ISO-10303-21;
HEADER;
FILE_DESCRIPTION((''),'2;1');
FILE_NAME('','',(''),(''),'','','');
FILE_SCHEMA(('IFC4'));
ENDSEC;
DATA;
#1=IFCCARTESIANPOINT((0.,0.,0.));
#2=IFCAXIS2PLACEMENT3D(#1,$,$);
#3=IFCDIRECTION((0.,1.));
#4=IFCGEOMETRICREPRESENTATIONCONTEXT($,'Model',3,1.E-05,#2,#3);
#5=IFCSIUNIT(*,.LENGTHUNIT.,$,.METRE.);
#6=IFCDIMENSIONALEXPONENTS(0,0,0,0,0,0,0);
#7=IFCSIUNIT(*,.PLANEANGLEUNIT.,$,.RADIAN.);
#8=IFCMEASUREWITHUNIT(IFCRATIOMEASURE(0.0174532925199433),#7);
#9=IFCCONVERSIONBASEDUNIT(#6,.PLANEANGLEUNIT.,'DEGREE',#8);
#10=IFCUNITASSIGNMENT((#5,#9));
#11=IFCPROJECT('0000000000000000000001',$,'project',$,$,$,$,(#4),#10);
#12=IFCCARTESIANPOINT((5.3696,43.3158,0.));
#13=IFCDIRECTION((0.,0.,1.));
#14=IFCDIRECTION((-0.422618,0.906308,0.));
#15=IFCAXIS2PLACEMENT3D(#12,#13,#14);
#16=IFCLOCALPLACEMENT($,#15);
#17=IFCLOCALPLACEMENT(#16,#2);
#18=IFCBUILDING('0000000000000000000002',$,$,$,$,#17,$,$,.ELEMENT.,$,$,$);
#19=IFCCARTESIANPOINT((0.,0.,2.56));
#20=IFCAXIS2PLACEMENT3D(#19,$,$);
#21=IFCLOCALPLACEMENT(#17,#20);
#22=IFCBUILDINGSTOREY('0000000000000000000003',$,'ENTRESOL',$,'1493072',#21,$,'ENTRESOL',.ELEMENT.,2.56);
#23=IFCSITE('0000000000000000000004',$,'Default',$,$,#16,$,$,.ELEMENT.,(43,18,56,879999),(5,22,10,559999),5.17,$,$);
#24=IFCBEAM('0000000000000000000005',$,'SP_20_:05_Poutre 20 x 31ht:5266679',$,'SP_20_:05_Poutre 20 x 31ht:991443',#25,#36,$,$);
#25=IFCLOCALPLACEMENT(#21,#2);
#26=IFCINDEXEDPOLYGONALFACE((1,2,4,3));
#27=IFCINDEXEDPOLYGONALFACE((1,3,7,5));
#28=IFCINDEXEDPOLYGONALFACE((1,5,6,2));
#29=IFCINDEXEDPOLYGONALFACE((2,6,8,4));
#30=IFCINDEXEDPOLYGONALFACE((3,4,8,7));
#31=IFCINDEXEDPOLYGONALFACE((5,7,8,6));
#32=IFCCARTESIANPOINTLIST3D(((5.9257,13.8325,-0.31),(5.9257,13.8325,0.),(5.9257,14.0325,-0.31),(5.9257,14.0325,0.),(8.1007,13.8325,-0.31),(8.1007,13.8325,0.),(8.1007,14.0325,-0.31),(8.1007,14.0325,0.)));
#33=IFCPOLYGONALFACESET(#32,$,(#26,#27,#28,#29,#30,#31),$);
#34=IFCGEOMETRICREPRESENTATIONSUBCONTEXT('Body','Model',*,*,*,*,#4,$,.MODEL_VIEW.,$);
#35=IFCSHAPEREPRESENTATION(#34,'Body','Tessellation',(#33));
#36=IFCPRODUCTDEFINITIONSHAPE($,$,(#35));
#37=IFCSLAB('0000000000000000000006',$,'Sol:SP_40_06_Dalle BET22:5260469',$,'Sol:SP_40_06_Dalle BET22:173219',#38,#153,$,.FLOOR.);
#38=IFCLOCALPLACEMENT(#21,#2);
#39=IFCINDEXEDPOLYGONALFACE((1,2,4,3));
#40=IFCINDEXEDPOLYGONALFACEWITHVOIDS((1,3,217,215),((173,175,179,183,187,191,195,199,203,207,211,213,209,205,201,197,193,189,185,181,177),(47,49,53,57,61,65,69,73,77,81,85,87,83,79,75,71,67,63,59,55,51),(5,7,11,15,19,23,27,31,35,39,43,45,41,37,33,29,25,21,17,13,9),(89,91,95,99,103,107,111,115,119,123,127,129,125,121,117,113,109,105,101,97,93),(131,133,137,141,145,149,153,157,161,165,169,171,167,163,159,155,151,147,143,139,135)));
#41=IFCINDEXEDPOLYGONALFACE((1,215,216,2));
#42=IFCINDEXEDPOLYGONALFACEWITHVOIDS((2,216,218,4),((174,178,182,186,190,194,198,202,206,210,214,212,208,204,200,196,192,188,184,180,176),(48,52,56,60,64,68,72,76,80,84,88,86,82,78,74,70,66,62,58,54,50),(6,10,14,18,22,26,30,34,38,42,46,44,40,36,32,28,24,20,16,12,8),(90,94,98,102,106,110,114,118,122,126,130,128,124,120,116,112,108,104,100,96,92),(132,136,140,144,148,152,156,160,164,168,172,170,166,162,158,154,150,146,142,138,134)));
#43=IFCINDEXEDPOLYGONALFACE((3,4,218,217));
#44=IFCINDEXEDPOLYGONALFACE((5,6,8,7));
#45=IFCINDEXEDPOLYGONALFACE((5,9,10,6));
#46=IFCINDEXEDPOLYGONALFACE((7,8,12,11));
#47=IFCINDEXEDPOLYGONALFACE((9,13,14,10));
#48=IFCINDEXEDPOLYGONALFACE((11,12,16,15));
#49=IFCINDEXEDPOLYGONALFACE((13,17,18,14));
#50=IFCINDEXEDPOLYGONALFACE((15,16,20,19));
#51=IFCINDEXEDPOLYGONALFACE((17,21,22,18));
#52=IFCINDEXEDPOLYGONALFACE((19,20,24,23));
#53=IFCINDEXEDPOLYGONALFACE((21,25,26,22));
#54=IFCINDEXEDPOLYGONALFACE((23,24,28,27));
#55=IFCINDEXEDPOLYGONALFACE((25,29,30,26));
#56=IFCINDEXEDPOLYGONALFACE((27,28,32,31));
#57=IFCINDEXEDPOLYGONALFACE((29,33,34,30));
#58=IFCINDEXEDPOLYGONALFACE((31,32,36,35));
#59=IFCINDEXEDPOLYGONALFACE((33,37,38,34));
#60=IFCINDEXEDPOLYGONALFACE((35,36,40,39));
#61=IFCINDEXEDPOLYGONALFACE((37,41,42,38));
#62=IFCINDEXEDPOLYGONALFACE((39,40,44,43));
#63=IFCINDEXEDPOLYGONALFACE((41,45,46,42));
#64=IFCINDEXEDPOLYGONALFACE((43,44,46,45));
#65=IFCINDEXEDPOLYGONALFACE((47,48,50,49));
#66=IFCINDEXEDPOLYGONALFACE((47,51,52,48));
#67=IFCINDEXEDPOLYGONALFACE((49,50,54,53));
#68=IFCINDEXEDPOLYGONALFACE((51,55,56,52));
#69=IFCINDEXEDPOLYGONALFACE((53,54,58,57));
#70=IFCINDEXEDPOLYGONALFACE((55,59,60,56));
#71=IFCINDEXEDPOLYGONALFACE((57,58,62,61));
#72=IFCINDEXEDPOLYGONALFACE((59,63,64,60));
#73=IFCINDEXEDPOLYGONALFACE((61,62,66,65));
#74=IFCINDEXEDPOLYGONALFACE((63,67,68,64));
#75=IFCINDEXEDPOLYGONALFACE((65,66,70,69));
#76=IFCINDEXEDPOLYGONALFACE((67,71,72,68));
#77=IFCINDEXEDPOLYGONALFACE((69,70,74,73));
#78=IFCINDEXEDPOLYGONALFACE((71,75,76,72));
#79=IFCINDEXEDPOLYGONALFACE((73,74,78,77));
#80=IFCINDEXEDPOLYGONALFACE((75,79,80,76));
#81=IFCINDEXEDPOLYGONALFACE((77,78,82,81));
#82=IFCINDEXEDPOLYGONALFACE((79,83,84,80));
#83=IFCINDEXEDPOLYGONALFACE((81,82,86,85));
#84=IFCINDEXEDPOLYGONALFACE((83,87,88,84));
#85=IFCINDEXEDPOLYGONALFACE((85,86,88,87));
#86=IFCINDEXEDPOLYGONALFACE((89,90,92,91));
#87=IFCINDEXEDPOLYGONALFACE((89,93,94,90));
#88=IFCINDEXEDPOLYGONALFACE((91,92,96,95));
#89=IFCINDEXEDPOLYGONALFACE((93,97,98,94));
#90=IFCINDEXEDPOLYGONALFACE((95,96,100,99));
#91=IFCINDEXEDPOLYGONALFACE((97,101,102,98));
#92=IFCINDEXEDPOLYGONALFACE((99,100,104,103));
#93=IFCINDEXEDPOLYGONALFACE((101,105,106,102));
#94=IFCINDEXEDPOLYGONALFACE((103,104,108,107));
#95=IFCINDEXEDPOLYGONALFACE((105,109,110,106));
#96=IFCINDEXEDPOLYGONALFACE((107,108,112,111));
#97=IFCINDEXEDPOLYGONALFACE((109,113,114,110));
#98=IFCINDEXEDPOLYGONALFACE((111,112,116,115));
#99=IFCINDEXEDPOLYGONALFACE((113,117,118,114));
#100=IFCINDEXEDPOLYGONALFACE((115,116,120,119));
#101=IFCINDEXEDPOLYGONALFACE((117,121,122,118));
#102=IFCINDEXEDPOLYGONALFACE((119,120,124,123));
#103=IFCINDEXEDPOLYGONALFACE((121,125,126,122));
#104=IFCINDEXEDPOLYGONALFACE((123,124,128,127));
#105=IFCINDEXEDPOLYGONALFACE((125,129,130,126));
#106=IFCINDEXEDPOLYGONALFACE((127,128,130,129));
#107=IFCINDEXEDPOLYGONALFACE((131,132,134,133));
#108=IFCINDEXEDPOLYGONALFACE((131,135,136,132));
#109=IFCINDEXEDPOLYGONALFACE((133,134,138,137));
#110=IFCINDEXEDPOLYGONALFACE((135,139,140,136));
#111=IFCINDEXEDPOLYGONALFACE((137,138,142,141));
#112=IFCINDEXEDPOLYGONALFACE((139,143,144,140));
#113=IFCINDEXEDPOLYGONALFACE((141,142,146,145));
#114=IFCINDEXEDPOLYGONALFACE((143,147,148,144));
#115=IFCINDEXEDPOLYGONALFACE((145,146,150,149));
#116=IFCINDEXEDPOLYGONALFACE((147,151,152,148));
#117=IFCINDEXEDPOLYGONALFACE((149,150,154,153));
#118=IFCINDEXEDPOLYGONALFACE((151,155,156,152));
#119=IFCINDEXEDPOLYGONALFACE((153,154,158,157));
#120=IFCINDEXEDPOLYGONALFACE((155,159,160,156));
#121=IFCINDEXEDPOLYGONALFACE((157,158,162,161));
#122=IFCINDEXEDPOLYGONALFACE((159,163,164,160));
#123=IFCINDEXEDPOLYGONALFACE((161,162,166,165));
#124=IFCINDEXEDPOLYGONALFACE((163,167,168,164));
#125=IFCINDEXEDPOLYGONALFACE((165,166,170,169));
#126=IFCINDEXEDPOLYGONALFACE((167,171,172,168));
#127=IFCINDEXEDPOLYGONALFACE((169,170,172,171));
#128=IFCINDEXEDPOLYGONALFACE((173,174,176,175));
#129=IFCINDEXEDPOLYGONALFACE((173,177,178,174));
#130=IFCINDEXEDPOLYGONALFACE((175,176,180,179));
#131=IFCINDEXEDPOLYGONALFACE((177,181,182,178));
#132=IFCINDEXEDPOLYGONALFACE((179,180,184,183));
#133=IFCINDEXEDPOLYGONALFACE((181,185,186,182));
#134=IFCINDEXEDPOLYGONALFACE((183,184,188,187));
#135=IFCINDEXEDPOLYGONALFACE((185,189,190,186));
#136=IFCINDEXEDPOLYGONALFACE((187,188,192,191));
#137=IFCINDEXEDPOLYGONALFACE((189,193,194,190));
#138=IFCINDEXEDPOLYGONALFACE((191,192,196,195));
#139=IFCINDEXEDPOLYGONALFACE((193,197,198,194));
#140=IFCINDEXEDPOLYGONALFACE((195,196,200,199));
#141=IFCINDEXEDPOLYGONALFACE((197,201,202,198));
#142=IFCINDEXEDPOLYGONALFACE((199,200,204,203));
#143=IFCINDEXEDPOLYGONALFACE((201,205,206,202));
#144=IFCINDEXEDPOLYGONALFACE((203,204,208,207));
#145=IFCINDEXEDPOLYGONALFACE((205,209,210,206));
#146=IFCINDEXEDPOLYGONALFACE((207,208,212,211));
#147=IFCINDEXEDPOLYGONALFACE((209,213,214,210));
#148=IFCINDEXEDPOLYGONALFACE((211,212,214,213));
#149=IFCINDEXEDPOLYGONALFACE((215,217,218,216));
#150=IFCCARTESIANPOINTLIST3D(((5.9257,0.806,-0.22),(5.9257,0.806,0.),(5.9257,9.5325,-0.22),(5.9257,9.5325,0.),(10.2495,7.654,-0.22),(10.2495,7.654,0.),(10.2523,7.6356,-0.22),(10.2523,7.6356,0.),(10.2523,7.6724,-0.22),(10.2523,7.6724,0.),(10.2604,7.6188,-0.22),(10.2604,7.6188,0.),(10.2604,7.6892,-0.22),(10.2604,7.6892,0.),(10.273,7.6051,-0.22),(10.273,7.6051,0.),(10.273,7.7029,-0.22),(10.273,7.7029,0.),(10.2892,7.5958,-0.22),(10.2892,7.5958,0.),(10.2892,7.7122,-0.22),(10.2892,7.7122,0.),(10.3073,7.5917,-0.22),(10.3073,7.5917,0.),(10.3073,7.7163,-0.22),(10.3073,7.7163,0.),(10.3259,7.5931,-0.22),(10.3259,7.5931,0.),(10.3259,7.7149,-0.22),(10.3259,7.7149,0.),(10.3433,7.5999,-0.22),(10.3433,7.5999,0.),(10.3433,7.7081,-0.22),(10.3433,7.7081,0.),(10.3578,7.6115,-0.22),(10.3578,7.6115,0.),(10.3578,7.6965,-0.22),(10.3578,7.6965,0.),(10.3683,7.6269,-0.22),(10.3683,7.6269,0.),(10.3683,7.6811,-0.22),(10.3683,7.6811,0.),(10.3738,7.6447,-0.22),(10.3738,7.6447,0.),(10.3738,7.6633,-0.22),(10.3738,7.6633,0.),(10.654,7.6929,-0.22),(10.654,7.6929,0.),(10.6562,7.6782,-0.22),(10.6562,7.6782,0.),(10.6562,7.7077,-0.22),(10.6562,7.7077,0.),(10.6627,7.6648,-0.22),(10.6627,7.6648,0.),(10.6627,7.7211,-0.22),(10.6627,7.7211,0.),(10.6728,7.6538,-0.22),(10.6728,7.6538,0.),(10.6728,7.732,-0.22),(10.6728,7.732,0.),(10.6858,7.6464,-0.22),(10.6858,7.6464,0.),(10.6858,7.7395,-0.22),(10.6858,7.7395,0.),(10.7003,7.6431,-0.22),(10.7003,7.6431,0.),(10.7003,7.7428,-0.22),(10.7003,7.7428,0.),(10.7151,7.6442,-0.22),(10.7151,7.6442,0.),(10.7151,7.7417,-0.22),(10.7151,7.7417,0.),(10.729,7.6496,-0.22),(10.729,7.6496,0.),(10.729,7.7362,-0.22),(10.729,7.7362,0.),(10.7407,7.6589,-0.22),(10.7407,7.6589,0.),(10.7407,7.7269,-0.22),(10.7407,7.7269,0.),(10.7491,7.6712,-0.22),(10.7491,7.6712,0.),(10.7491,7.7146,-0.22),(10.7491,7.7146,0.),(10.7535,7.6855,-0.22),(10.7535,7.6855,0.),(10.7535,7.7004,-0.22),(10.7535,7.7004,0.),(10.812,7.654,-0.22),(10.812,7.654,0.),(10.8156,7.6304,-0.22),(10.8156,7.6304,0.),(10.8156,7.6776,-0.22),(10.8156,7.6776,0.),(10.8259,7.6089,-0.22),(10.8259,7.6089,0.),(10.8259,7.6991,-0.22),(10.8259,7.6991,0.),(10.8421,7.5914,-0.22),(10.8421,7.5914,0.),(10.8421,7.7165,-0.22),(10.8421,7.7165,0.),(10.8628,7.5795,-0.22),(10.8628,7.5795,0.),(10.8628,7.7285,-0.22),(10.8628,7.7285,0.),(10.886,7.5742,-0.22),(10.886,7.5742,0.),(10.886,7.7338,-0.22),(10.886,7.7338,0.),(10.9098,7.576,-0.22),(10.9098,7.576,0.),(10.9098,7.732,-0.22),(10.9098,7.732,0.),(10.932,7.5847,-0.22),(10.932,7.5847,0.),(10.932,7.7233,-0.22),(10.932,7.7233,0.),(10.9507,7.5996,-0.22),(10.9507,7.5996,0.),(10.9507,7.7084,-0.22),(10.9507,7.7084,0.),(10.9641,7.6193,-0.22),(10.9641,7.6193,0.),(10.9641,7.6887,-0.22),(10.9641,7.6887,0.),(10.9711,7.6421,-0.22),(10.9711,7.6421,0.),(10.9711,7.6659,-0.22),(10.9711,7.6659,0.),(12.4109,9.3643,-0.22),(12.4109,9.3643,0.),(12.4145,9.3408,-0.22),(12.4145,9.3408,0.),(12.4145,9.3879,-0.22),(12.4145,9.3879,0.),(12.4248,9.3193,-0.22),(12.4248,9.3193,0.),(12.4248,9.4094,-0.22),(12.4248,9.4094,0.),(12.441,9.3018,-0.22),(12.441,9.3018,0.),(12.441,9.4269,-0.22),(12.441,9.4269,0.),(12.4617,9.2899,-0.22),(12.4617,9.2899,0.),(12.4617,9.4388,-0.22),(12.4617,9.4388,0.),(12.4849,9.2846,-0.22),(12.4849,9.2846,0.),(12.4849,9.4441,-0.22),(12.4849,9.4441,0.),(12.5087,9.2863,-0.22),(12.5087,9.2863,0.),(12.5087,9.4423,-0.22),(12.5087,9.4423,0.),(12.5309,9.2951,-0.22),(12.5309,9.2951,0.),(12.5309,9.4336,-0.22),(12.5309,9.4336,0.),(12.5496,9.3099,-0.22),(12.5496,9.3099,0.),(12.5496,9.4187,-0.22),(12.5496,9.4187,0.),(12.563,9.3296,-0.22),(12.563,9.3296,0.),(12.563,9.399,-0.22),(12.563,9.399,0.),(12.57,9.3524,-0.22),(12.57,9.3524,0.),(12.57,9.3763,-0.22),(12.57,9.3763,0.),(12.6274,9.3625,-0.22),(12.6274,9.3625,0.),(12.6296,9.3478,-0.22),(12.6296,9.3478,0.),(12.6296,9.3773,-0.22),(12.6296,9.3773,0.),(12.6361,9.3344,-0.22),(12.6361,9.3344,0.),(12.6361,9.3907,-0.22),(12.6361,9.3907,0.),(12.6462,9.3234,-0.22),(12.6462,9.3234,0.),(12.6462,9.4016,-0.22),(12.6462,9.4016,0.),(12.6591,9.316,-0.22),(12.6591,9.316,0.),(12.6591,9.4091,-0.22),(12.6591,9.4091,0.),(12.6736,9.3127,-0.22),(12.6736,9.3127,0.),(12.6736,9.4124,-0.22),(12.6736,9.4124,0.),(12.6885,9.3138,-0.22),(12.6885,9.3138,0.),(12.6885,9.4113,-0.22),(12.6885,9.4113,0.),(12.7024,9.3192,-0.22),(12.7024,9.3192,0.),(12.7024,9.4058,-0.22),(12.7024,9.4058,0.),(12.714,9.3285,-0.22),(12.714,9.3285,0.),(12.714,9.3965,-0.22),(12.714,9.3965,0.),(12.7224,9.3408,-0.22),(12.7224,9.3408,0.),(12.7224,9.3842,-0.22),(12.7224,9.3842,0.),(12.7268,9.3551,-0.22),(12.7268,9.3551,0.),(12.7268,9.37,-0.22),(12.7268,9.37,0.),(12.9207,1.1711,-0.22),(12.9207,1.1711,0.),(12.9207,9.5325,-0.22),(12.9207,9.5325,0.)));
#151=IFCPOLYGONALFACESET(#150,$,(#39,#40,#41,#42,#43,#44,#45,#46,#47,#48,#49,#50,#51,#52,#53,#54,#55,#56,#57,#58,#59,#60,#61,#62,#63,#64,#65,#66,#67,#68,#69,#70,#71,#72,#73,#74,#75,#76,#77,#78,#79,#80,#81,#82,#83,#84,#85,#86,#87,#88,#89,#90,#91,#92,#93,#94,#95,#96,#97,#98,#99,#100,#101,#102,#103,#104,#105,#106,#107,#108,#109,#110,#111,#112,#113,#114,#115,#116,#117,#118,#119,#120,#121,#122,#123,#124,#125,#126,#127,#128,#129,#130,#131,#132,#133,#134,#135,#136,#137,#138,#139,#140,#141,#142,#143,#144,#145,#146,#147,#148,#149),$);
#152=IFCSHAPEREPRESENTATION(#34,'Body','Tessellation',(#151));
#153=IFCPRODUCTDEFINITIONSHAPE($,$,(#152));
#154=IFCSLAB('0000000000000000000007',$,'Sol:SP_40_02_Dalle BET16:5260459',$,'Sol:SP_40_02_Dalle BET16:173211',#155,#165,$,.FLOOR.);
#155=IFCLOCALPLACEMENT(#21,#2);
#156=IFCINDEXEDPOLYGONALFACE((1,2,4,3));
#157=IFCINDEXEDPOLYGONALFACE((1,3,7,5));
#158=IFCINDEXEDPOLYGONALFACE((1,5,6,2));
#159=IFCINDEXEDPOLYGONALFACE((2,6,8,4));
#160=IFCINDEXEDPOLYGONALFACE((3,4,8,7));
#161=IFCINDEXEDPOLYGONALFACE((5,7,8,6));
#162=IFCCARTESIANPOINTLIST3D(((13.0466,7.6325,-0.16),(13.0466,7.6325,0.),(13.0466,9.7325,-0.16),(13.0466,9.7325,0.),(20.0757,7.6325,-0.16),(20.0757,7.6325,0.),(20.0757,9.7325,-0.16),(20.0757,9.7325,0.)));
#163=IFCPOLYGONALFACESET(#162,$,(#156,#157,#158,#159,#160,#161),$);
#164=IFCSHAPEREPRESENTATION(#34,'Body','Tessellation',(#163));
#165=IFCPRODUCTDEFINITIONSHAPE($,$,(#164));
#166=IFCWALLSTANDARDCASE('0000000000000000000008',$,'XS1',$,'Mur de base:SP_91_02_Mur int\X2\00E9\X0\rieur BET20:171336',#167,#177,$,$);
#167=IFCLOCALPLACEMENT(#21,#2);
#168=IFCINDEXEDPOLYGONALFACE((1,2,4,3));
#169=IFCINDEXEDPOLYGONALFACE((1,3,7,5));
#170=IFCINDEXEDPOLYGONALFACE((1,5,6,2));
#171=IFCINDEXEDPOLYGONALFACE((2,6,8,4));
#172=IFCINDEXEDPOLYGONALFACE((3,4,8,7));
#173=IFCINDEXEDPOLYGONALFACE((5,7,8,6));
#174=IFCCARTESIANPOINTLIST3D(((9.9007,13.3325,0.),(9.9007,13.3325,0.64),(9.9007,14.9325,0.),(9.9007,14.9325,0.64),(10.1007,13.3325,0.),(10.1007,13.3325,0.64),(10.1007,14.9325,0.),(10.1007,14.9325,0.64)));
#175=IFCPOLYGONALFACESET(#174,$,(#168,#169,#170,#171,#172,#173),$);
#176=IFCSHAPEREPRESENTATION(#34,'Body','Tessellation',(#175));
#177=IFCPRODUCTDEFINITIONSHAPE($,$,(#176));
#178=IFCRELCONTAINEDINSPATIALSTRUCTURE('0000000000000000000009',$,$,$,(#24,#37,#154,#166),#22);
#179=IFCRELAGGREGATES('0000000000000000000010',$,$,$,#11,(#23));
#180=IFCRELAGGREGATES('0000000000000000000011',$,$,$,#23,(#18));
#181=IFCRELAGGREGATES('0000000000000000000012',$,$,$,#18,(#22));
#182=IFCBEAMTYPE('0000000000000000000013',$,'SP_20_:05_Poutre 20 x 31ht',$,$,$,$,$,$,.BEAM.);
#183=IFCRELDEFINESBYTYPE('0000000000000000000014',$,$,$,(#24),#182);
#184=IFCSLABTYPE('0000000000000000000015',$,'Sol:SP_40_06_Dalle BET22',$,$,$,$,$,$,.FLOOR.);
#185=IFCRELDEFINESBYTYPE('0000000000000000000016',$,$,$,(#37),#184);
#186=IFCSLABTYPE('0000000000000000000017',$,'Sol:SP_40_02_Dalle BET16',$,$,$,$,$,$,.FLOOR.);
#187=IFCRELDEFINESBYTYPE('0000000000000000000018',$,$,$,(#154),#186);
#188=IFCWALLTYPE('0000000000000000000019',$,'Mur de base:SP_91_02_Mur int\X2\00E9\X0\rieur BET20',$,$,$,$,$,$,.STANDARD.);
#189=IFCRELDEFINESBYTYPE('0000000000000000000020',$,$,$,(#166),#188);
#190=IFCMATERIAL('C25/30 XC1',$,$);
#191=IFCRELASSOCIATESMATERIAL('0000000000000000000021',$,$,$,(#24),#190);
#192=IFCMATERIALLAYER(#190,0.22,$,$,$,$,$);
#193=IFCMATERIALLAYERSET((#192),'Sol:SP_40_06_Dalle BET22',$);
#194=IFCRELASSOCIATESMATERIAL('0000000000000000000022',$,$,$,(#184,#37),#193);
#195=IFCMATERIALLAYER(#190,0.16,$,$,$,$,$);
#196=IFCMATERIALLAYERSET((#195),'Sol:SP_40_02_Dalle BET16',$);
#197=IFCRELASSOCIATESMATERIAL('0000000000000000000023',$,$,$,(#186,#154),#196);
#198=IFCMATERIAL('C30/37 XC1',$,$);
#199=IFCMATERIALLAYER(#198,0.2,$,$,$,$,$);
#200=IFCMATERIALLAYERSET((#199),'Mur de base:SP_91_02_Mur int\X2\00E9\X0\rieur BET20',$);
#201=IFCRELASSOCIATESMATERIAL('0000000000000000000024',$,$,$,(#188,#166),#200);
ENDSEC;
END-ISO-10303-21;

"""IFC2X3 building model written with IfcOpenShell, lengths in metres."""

from ifc_helpers import new_model, entity, si_unit, converted_unit, direction, frame, frame_2d, origin, place, context, subcontext, project, spatial, polyline, rectangle, circle, outline, extrude, clip, halfspace, material, layer, layer_set, layer_usage, type_object, element, save


model = new_model("IFC2X3")

# Units and contexts
model_context = context("Model", 3, precision=1e-05, world=origin(), true_north=direction((0.0, 1.0)))
body_context = subcontext(model_context, "Body", "Model", "MODEL_VIEW")
ifc_project = project(units=[si_unit("LENGTHUNIT", "METRE"), converted_unit("PLANEANGLEUNIT", "DEGREE", entity("IfcRatioMeasure", 0.0174532925199433), si_unit("PLANEANGLEUNIT", "RADIAN"), dimensions=[0, 0, 0, 0, 0, 0, 0])], contexts=[model_context])

# Site, building, storey
site_placement = place(None, frame((5.3696, 43.3158, 0.0), z_axis=(0.0, 0.0, 1.0), x_axis=(-0.422618, 0.906308, 0.0)))
site = spatial("IfcSite", under=ifc_project, at=site_placement, Name="Default", CompositionType="ELEMENT", RefLatitude=(43, 18, 56, 879999), RefLongitude=(5, 22, 10, 559999), RefElevation=5.17)
building_placement = place(site_placement, origin())
building = spatial("IfcBuilding", under=site, at=building_placement, CompositionType="ELEMENT")
storey_placement = place(building_placement, frame((0.0, 0.0, 2.56)))
storey = spatial("IfcBuildingStorey", under=building, at=storey_placement, Name="ENTRESOL", ObjectType="1493072", LongName="ENTRESOL", CompositionType="ELEMENT", Elevation=2.56)

# Beam
ifc_material_1 = material(Name="C25/30 XC1")
beam_type_1 = type_object("IfcBeamType", Name="SP_20_:05_Poutre 20 x 31ht", PredefinedType="BEAM")
beam_1_placement = place(storey_placement, frame((8.2007, 13.9325, 0.0), z_axis=(0.0, 0.0, 1.0), x_axis=(-1.0, 0.0, 0.0)))
element("IfcBeam", 1, at=beam_1_placement, inside=storey, type_object=beam_type_1, material=ifc_material_1, Name="SP_20_:05_Poutre 20 x 31ht:5266679", ObjectType="SP_20_:05_Poutre 20 x 31ht:991443", context=body_context, shape_type="SweptSolid", body=[
    extrude(rectangle(XDim=0.31, YDim=0.2, at=frame_2d((0.0, 0.0), x_axis=(1.0, 0.0))), frame((0.1, 0.0, -0.155), z_axis=(1.0, 0.0, 0.0), x_axis=(0.0, 0.0, -1.0)), (0.0, 0.0, 1.0), 2.175),
])

# Slab, openings
ifc_layer_1 = layer(ifc_material_1, 0.22)
ifc_layer_set_1 = layer_set([ifc_layer_1], Name="Sol:SP_40_06_Dalle BET22")
ifc_layer_usage_1 = layer_usage(ifc_layer_set_1, "AXIS3", "POSITIVE", 0.0)
slab_type_1 = type_object("IfcSlabType", Name="Sol:SP_40_06_Dalle BET22", PredefinedType="FLOOR", material=ifc_layer_set_1)
slab_1_placement = place(storey_placement, frame((5.9257, 0.806, -0.22)))
slab_1 = element("IfcSlab", 2, at=slab_1_placement, inside=storey, type_object=slab_type_1, material=ifc_layer_usage_1, Name="Sol:SP_40_06_Dalle BET22:5260469", ObjectType="Sol:SP_40_06_Dalle BET22:173219", PredefinedType="FLOOR", context=body_context, shape_type="SweptSolid", body=[
    extrude(outline(polyline([(3.4975, 4.3633), (-3.4975, 4.3633), (-3.4975, -3.9982), (3.4975, -4.3633), (3.4975, 4.3633)])), frame((3.4975, 4.3633, 0.22), z_axis=(0.0, 0.0, -1.0), x_axis=(-1.0, 0.0, 0.0)), (0.0, 0.0, 1.0), 0.22),
])
opening_1_placement = place(storey_placement, frame((5.9257, 0.806, -0.22)))
element("IfcOpeningElement", 3, at=opening_1_placement, cuts=slab_1, ObjectType="Opening", context=body_context, shape_type="SweptSolid", body=[
    extrude(circle(Radius=0.08, at=frame_2d((-3.0678, 4.1951), x_axis=(1.0, 0.0))), frame((3.4975, 4.3633, 0.22), z_axis=(0.0, 0.0, -1.0), x_axis=(-1.0, 0.0, 0.0)), (0.0, 0.0, 1.0), 0.22),
])
opening_2_placement = place(storey_placement, frame((5.9257, 0.806, -0.22)))
element("IfcOpeningElement", 4, at=opening_2_placement, cuts=slab_1, ObjectType="Opening", context=body_context, shape_type="SweptSolid", body=[
    extrude(circle(Radius=0.05, at=frame_2d((-3.2542, 4.1933), x_axis=(1.0, 0.0))), frame((3.4975, 4.3633, 0.22), z_axis=(0.0, 0.0, -1.0), x_axis=(-1.0, 0.0, 0.0)), (0.0, 0.0, 1.0), 0.22),
])
opening_3_placement = place(storey_placement, frame((5.9257, 0.806, -0.22)))
element("IfcOpeningElement", 5, at=opening_3_placement, cuts=slab_1, ObjectType="Opening", context=body_context, shape_type="SweptSolid", body=[
    extrude(circle(Radius=0.08, at=frame_2d((-1.4689, 2.4847), x_axis=(1.0, 0.0))), frame((3.4975, 4.3633, 0.22), z_axis=(0.0, 0.0, -1.0), x_axis=(-1.0, 0.0, 0.0)), (0.0, 0.0, 1.0), 0.22),
])
opening_4_placement = place(storey_placement, frame((5.9257, 0.806, -0.22)))
element("IfcOpeningElement", 6, at=opening_4_placement, cuts=slab_1, ObjectType="Opening", context=body_context, shape_type="SweptSolid", body=[
    extrude(circle(Radius=0.05, at=frame_2d((-1.2809, 2.5237), x_axis=(1.0, 0.0))), frame((3.4975, 4.3633, 0.22), z_axis=(0.0, 0.0, -1.0), x_axis=(-1.0, 0.0, 0.0)), (0.0, 0.0, 1.0), 0.22),
])
opening_5_placement = place(storey_placement, frame((5.9257, 0.806, -0.22)))
element("IfcOpeningElement", 7, at=opening_5_placement, cuts=slab_1, ObjectType="Opening", context=body_context, shape_type="SweptSolid", body=[
    extrude(circle(Radius=0.0625, at=frame_2d((-0.8889, 2.4847), x_axis=(1.0, 0.0))), frame((3.4975, 4.3633, 0.22), z_axis=(0.0, 0.0, -1.0), x_axis=(-1.0, 0.0, 0.0)), (0.0, 0.0, 1.0), 0.22),
])

# Slab
ifc_layer_2 = layer(ifc_material_1, 0.16)
ifc_layer_set_2 = layer_set([ifc_layer_2], Name="Sol:SP_40_02_Dalle BET16")
ifc_layer_usage_2 = layer_usage(ifc_layer_set_2, "AXIS3", "POSITIVE", 0.0)
slab_type_2 = type_object("IfcSlabType", Name="Sol:SP_40_02_Dalle BET16", PredefinedType="FLOOR", material=ifc_layer_set_2)
slab_2_placement = place(storey_placement, origin())
element("IfcSlab", 8, at=slab_2_placement, inside=storey, type_object=slab_type_2, material=ifc_layer_usage_2, Name="Sol:SP_40_02_Dalle BET16:5260459", ObjectType="Sol:SP_40_02_Dalle BET16:173211", PredefinedType="FLOOR", context=body_context, shape_type="SweptSolid", body=[
    extrude(rectangle(XDim=2.1, YDim=7.029, at=frame_2d((0.0, 0.0), x_axis=(1.0, 0.0))), frame((16.5612, 8.6825, 0.0), z_axis=(0.0, 0.0, -1.0), x_axis=(0.0, 1.0, 0.0)), (0.0, 0.0, 1.0), 0.16),
])

# Wall
ifc_material_2 = material(Name="C30/37 XC1")
ifc_layer_3 = layer(ifc_material_2, 0.2)
ifc_layer_set_3 = layer_set([ifc_layer_3], Name="Mur de base:SP_91_02_Mur intérieur BET20")
ifc_layer_usage_3 = layer_usage(ifc_layer_set_3, "AXIS2", "NEGATIVE", 0.1)
wall_type_1 = type_object("IfcWallType", Name="Mur de base:SP_91_02_Mur intérieur BET20", PredefinedType="STANDARD", material=ifc_layer_set_3)
wall_1_placement = place(storey_placement, frame((10.0007, 13.3325, 0.0), z_axis=(0.0, 0.0, 1.0), x_axis=(0.0, 1.0, 0.0)))
element("IfcWallStandardCase", 9, at=wall_1_placement, inside=storey, type_object=wall_type_1, material=ifc_layer_usage_3, Name="XS1", ObjectType="Mur de base:SP_91_02_Mur intérieur BET20:171336", context=body_context, shape_type="Clipping", body=[
    clip(extrude(rectangle(XDim=1.6, YDim=0.2, at=frame_2d((0.8, 0.0), x_axis=(-1.0, 0.0))), origin(), (0.0, 0.0, 1.0), 0.64), halfspace(frame((0.0, 0.0, -2.56)), True)),
])

save(model, "model.ifc")
